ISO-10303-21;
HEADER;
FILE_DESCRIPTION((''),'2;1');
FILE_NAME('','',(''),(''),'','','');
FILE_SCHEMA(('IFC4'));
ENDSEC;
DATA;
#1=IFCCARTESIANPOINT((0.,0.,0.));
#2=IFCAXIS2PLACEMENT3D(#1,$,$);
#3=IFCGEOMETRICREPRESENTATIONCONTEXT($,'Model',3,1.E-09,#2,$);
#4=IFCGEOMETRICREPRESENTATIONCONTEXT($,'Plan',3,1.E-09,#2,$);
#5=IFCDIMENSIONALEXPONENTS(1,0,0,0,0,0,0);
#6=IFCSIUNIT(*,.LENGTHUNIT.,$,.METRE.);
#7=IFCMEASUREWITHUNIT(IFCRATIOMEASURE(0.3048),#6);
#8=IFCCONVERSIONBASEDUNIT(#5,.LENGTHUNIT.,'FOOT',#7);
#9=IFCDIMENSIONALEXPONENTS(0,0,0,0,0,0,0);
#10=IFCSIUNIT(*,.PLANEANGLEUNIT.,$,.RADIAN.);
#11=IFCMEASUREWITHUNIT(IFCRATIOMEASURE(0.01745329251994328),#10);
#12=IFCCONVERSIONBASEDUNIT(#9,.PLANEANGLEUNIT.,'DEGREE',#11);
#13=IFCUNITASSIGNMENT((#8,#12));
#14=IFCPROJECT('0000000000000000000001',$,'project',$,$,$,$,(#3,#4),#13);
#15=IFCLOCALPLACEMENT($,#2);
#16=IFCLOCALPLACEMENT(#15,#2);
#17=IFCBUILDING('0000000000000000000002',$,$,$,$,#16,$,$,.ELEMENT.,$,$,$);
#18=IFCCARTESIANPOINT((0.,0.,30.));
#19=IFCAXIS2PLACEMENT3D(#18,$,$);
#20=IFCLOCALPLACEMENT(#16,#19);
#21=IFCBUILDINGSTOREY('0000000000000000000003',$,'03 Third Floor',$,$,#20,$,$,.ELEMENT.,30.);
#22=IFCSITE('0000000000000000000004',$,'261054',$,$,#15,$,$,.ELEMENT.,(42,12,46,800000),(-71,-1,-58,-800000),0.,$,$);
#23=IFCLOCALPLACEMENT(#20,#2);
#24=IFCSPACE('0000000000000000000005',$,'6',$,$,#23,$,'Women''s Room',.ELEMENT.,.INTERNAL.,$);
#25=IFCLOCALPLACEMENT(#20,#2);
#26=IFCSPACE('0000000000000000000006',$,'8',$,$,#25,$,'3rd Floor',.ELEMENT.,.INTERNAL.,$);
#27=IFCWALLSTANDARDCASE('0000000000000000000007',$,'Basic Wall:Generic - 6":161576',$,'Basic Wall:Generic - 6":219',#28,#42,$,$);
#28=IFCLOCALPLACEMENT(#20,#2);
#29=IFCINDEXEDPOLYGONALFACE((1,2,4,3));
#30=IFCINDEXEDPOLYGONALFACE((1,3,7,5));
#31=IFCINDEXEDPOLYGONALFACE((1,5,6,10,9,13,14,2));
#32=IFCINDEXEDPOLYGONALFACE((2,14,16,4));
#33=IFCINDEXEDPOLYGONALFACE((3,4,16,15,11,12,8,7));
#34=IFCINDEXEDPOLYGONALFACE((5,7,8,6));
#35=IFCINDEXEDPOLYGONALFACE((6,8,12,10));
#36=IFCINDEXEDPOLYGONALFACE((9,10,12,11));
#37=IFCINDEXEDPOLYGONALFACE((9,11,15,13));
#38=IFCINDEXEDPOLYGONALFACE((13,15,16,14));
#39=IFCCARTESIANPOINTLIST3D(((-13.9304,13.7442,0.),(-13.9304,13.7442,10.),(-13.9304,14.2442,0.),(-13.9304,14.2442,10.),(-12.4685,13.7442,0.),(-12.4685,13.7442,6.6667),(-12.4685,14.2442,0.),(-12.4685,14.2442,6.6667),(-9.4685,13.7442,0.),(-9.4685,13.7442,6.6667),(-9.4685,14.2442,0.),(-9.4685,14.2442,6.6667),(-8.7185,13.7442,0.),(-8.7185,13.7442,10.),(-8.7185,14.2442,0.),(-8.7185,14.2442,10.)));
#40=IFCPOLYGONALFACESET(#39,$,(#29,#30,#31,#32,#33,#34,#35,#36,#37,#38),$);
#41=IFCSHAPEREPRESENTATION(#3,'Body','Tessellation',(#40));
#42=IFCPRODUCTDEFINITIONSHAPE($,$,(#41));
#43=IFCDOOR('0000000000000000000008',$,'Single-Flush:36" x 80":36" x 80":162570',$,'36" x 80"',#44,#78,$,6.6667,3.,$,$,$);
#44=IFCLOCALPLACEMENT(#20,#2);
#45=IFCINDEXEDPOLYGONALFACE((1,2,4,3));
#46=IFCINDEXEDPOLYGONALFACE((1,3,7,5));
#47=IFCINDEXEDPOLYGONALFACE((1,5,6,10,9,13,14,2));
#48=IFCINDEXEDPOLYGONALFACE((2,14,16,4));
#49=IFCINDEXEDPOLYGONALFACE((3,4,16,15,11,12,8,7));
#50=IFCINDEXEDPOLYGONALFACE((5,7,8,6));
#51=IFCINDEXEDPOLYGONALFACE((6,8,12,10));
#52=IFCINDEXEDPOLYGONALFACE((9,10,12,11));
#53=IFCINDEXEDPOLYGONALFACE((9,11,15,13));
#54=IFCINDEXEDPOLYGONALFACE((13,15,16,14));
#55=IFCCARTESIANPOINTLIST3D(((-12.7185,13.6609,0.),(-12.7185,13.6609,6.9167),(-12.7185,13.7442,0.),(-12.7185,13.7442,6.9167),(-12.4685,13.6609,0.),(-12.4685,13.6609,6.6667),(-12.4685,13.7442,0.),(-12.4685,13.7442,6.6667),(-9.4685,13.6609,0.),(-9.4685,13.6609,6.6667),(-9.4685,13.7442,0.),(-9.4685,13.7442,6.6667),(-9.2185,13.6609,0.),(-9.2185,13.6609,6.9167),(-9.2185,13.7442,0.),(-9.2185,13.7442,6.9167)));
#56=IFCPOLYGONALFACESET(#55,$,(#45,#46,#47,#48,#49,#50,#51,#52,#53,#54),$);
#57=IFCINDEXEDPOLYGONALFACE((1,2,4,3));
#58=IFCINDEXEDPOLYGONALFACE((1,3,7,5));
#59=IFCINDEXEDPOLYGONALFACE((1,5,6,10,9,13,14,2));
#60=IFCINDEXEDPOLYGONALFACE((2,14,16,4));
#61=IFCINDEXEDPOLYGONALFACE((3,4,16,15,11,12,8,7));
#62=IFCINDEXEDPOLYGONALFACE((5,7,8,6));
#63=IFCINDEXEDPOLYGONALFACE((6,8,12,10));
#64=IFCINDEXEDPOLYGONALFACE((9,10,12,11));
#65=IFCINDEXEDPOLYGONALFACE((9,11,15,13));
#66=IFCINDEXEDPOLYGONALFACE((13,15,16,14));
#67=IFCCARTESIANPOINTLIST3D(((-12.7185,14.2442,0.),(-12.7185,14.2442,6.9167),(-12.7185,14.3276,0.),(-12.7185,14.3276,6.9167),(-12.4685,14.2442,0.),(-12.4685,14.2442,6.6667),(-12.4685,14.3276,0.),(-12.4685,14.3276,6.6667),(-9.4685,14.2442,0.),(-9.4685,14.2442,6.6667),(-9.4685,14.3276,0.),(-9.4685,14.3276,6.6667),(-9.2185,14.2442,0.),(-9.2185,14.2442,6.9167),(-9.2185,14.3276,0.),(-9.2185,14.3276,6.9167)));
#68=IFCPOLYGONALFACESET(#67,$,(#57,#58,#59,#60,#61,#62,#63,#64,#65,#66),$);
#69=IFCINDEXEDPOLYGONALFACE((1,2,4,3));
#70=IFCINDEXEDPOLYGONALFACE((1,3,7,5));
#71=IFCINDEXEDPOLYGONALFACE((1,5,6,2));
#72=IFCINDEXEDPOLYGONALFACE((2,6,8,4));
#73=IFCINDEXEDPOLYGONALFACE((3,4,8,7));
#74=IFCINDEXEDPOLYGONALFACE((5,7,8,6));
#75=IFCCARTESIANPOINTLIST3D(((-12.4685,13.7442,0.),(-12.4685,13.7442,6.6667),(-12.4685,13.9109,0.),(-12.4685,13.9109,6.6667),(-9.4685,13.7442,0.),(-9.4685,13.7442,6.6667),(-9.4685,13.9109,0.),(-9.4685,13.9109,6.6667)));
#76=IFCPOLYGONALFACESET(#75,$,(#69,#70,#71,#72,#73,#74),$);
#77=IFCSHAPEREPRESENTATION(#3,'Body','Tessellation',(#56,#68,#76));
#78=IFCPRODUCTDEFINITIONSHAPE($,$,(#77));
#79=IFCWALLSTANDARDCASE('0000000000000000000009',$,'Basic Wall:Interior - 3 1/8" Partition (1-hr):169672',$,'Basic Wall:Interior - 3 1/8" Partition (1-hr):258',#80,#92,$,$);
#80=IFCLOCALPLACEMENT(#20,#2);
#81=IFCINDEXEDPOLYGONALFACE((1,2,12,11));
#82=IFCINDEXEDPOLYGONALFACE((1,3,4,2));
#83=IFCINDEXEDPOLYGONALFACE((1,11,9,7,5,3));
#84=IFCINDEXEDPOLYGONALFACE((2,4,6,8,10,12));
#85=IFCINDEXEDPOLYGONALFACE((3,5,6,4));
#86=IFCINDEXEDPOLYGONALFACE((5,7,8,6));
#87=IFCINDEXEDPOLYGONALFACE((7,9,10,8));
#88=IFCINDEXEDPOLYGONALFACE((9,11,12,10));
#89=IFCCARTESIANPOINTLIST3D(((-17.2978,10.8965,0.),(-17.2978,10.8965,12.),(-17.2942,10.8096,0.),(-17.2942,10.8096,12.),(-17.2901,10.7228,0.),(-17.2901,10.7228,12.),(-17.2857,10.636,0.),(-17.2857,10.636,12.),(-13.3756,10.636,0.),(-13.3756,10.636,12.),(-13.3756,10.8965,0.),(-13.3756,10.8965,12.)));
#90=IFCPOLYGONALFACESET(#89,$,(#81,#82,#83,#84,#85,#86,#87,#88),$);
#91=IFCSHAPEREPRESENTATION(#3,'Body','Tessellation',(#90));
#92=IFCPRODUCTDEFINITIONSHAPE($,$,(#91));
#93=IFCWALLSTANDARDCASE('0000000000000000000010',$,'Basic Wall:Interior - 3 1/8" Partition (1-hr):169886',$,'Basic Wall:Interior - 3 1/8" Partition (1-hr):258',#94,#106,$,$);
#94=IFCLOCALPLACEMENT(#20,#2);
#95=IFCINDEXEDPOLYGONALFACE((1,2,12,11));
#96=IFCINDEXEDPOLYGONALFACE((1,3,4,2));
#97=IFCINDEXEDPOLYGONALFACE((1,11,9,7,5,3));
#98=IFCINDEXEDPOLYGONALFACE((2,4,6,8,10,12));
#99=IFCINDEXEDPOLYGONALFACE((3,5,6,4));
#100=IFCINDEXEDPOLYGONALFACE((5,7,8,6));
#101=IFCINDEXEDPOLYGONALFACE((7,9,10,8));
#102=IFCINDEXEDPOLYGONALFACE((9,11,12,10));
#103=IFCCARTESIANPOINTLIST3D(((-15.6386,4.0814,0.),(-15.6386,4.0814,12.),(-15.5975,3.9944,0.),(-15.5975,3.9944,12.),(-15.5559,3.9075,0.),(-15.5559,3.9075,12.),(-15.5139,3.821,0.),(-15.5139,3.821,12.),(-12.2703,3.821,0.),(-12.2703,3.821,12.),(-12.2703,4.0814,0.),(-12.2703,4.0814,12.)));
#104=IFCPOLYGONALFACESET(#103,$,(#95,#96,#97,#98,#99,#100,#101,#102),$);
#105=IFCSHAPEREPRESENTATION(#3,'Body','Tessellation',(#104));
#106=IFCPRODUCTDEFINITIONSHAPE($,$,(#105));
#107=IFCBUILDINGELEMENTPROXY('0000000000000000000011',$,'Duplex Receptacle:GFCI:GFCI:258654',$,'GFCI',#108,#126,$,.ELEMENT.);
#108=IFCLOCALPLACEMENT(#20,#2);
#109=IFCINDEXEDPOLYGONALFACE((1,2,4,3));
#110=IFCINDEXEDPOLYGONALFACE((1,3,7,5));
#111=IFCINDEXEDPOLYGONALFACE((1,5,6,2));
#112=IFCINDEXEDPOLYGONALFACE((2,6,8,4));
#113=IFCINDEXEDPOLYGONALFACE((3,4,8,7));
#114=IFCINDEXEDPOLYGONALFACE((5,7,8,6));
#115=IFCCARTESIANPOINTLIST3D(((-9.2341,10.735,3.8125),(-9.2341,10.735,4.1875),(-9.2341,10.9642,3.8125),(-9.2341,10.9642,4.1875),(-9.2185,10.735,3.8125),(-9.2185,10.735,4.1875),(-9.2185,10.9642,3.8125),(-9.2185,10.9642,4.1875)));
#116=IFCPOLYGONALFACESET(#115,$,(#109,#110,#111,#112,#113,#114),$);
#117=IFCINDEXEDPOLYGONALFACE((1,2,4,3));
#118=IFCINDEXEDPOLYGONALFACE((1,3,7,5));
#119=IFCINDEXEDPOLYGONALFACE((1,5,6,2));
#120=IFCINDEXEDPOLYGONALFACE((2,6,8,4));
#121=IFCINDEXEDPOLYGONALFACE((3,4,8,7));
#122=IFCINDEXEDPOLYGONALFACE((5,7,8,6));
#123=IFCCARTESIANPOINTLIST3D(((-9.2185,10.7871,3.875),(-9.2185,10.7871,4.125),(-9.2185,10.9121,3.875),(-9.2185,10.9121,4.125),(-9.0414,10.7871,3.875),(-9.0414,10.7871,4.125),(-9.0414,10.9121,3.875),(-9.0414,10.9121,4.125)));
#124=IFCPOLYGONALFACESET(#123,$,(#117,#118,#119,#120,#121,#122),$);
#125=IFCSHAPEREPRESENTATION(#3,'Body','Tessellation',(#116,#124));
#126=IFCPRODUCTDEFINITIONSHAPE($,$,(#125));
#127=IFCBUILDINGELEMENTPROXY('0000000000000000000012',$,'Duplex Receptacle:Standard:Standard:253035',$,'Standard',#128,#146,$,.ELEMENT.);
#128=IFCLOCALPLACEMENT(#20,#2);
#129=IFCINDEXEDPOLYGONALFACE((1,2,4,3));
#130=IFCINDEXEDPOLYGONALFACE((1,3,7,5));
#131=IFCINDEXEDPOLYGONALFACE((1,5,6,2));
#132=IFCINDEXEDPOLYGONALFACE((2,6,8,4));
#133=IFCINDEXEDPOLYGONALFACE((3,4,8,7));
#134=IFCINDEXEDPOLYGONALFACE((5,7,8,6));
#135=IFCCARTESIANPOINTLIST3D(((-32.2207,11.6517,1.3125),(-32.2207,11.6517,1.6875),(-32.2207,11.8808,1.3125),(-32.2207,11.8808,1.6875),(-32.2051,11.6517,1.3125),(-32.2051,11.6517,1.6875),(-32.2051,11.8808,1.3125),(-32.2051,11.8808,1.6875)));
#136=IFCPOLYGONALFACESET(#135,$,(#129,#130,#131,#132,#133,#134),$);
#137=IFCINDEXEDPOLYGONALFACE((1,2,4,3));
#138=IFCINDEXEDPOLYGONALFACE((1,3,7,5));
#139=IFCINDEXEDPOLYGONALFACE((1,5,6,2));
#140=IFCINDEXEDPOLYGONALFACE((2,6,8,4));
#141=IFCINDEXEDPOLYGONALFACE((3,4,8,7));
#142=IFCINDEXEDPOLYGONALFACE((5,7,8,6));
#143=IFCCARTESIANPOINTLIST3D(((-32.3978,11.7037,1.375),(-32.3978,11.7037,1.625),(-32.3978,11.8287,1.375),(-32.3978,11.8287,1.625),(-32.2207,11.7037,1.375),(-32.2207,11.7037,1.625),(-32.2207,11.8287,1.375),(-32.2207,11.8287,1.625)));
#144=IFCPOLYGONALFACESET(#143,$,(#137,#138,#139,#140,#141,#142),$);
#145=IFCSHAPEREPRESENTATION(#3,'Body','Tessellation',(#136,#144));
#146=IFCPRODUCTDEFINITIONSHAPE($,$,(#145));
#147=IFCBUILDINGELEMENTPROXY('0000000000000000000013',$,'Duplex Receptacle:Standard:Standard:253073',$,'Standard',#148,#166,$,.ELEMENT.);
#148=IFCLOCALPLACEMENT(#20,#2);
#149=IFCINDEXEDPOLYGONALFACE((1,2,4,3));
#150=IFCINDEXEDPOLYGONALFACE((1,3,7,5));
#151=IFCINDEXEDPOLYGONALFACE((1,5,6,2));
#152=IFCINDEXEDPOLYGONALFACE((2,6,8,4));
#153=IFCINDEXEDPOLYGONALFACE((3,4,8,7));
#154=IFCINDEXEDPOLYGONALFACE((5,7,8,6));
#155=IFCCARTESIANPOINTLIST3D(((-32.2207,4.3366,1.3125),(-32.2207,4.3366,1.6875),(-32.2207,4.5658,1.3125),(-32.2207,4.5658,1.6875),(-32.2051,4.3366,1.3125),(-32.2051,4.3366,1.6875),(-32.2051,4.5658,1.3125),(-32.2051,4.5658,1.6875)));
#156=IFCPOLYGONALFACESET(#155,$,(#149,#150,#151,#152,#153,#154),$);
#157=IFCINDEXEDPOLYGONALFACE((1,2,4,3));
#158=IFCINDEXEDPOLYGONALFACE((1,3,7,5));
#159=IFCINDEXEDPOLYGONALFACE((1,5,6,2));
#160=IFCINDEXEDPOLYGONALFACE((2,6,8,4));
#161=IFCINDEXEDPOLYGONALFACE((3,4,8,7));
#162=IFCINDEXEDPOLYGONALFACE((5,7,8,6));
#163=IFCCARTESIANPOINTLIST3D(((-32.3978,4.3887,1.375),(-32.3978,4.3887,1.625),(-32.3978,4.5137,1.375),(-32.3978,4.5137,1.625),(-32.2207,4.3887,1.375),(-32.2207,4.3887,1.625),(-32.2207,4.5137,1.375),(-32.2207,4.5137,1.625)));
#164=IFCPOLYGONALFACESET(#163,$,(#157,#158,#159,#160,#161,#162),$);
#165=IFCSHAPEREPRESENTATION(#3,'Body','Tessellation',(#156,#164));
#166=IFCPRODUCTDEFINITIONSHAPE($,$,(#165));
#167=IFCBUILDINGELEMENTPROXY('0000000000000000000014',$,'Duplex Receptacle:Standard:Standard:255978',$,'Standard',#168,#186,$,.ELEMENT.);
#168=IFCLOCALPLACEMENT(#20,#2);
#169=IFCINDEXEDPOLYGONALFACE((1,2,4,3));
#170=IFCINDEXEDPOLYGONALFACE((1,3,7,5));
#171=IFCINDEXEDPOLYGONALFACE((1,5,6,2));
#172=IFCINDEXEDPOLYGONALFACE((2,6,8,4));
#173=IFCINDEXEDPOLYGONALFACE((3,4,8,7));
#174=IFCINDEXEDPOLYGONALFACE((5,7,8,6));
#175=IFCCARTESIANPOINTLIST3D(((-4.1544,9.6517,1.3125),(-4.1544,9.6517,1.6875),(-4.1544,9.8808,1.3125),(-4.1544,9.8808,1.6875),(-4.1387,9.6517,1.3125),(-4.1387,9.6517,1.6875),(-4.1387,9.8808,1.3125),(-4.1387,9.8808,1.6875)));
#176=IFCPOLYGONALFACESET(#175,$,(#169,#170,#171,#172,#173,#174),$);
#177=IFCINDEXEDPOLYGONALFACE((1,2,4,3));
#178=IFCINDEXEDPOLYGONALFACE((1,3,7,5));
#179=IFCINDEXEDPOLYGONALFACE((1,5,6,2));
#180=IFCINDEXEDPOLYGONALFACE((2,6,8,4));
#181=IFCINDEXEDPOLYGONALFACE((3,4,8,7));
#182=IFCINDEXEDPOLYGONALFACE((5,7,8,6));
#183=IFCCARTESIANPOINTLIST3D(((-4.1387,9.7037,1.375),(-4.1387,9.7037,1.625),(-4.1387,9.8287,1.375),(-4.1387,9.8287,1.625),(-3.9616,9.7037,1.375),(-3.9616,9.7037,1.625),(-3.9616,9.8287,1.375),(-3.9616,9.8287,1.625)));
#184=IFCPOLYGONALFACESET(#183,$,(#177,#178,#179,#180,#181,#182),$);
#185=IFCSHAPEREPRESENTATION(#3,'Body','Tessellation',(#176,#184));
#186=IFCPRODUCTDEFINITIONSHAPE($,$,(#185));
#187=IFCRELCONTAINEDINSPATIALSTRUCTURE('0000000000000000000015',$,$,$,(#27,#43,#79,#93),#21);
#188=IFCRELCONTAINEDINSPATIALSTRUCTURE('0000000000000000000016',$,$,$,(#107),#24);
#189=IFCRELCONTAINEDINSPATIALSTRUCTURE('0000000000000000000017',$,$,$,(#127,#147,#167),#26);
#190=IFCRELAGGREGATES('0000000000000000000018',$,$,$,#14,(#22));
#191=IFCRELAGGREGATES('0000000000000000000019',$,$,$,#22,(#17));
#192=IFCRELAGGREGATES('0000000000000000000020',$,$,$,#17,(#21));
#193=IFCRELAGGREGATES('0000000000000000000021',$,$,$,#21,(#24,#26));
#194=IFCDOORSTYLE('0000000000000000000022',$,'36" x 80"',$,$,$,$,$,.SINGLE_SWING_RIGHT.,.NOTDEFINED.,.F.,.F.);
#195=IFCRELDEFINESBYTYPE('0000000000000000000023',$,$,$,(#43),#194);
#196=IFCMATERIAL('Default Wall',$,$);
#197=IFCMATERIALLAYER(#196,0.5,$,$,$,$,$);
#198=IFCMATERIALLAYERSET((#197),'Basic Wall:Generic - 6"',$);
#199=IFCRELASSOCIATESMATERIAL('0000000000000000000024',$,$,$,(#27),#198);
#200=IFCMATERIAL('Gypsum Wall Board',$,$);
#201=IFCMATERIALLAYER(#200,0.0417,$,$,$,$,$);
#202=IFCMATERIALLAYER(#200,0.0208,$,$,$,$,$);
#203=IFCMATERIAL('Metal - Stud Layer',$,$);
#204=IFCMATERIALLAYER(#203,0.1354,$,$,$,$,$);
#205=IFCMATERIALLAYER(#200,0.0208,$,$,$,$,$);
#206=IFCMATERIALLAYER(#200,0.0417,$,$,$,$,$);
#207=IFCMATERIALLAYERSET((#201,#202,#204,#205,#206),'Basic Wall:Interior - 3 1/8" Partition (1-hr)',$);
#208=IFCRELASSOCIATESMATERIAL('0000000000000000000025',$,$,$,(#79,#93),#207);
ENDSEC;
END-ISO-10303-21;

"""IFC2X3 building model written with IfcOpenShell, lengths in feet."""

from ifc_helpers import new_model, entity, si_unit, converted_unit, frame, frame_2d, origin, origin_2d_with_axis, place, context, project, spatial, polyline, circle_curve, parameter, trimmed, segment, composite_curve, rectangle, outline, extrude, source, transform, mapped, material, layer, layer_set, layer_usage, type_object, type_shapes, element, fill, save


model = new_model("IFC2X3")

# Units and contexts
model_context = context("Model", 3, precision=1e-09, world=origin())
plan_context = context("Plan", 3, precision=1e-09, world=origin())
ifc_project = project(units=[converted_unit("LENGTHUNIT", "FOOT", entity("IfcRatioMeasure", 0.3048), si_unit("LENGTHUNIT", "METRE"), dimensions=[1, 0, 0, 0, 0, 0, 0]), converted_unit("PLANEANGLEUNIT", "DEGREE", entity("IfcRatioMeasure", 0.01745329251994328), si_unit("PLANEANGLEUNIT", "RADIAN"), dimensions=[0, 0, 0, 0, 0, 0, 0])], contexts=[model_context, plan_context])

# Site, building, storey
site_placement = place(None, origin())
site = spatial("IfcSite", under=ifc_project, at=site_placement, Name="261054", CompositionType="ELEMENT", RefLatitude=(42, 12, 46, 800000), RefLongitude=(-71, -1, -58, -800000), RefElevation=0.0)
building_placement = place(site_placement, origin())
building = spatial("IfcBuilding", under=site, at=building_placement, CompositionType="ELEMENT")
storey_placement = place(building_placement, frame((0.0, 0.0, 30.0)))
storey = spatial("IfcBuildingStorey", under=building, at=storey_placement, Name="03 Third Floor", CompositionType="ELEMENT", Elevation=30.0)

# Wall, opening, door
ifc_material_1 = material(Name="Default Wall")
ifc_layer_1 = layer(ifc_material_1, 0.5)
ifc_layer_set_1 = layer_set([ifc_layer_1], Name="Basic Wall:Generic - 6\"")
ifc_layer_usage_1 = layer_usage(ifc_layer_set_1, "AXIS2", "NEGATIVE", 0.25)
wall_1_placement = place(storey_placement, frame((-13.9304, 13.9942, 0.0)))
wall_1 = element("IfcWallStandardCase", 1, at=wall_1_placement, inside=storey, material=ifc_layer_usage_1, Name="Basic Wall:Generic - 6\":161576", ObjectType="Basic Wall:Generic - 6\":219", context=model_context, shape_type="SweptSolid", body=[
    extrude(rectangle(XDim=5.2119, YDim=0.5, at=frame_2d((2.606, 0.0), x_axis=(-1.0, 0.0))), origin(), (0.0, 0.0, 1.0), 10.0),
])
opening_1_placement = place(wall_1_placement, frame((4.4619, 0.25, 0.0)))
opening_1 = element("IfcOpeningElement", 2, at=opening_1_placement, cuts=wall_1, ObjectType="Opening", context=model_context, shape_type="SweptSolid", body=[
    extrude(rectangle(XDim=3.0, YDim=6.6667, at=frame_2d((3.3333, 1.5), x_axis=(0.0, 1.0))), frame((0.0, 0.0, 0.0), z_axis=(0.0, -1.0, 0.0), x_axis=(0.0, 0.0, 1.0)), (0.0, 0.0, 1.0), 0.5),
])
door_style = type_object("IfcDoorStyle", Name="36\" x 80\"", ConstructionType="NOTDEFINED", OperationType="SINGLE_SWING_RIGHT", ParameterTakesPrecedence=False, Sizeable=False)
shared_shape_1 = source(origin(), model_context, "Body", "SweptSolid", [
    extrude(outline(polyline([(-1.75, -3.5208), (1.75, -3.5208), (1.75, 3.3958), (1.5, 3.3958), (1.5, -3.2708), (-1.5, -3.2708), (-1.5, 3.3958), (-1.75, 3.3958), (-1.75, -3.5208)])), frame((1.5, 0.5, 3.3958), z_axis=(0.0, 1.0, 0.0), x_axis=(1.0, 0.0, 0.0)), (0.0, 0.0, 1.0), 0.0833),
    extrude(outline(polyline([(-3.5208, -1.75), (3.3958, -1.75), (3.3958, -1.5), (-3.2708, -1.5), (-3.2708, 1.5), (3.3958, 1.5), (3.3958, 1.75), (-3.5208, 1.75), (-3.5208, -1.75)])), frame((1.5, -0.0833, 3.3958), z_axis=(0.0, 1.0, 0.0), x_axis=(0.0, 0.0, -1.0)), (0.0, 0.0, 1.0), 0.0833),
    extrude(rectangle(XDim=0.1667, YDim=3.0, at=origin_2d_with_axis()), frame((1.5, 0.4167, 0.0), z_axis=(0.0, 0.0, 1.0), x_axis=(0.0, 1.0, 0.0)), (0.0, 0.0, 1.0), 6.6667),
])
type_shapes(door_style, [shared_shape_1])
door_1_placement = place(opening_1_placement, frame((0.0, 0.0, 0.0), z_axis=(0.0, 0.0, 1.0), x_axis=(-1.0, 0.0, 0.0)))
door_1 = element("IfcDoor", 3, at=door_1_placement, inside=storey, type_object=door_style, Name="Single-Flush:36\" x 80\":36\" x 80\":162570", ObjectType="36\" x 80\"", OverallHeight=6.6667, OverallWidth=3.0, context=model_context, shape_type="MappedRepresentation", body=[
    mapped(shared_shape_1, transform((0.0, 0.0, 0.0), scale=1.0)),
])
fill(opening_1, door_1)

# Walls
ifc_material_2 = material(Name="Gypsum Wall Board")
ifc_layer_2 = layer(ifc_material_2, 0.0417)
ifc_layer_3 = layer(ifc_material_2, 0.0208)
ifc_material_3 = material(Name="Metal - Stud Layer")
ifc_layer_4 = layer(ifc_material_3, 0.1354)
ifc_layer_5 = layer(ifc_material_2, 0.0208)
ifc_layer_6 = layer(ifc_material_2, 0.0417)
ifc_layer_set_2 = layer_set([ifc_layer_2, ifc_layer_3, ifc_layer_4, ifc_layer_5, ifc_layer_6], Name="Basic Wall:Interior - 3 1/8\" Partition (1-hr)")
ifc_layer_usage_2 = layer_usage(ifc_layer_set_2, "AXIS2", "NEGATIVE", 0.1302)
wall_2_placement = place(storey_placement, frame((-17.2978, 10.7662, 0.0)))
element("IfcWallStandardCase", 4, at=wall_2_placement, inside=storey, material=ifc_layer_usage_2, Name="Basic Wall:Interior - 3 1/8\" Partition (1-hr):169672", ObjectType="Basic Wall:Interior - 3 1/8\" Partition (1-hr):258", context=model_context, shape_type="SweptSolid", body=[
    extrude(outline(composite_curve([segment(polyline([(3.9222, -0.1302), (3.9222, 0.1302)]), True, "CONTINUOUS"), segment(polyline([(3.9222, 0.1302), (0.0, 0.1302)]), True, "CONTINUOUS"), segment(trimmed(circle_curve(frame_2d((17.6642, 0.8212), x_axis=(1.0, 0.0)), 17.6777), [parameter(182.240127)], [parameter(183.085093)], True, "PARAMETER"), True, "CONTINUOUS"), segment(polyline([(0.0121, -0.1302), (3.9222, -0.1302)]), True, "CONTINUOUS")], self_intersect=False)), origin(), (0.0, 0.0, 1.0), 12.0),
])
ifc_layer_usage_3 = layer_usage(ifc_layer_set_2, "AXIS2", "NEGATIVE", 0.1302)
wall_3_placement = place(storey_placement, frame((-15.6386, 3.9512, 0.0)))
element("IfcWallStandardCase", 5, at=wall_3_placement, inside=storey, material=ifc_layer_usage_3, Name="Basic Wall:Interior - 3 1/8\" Partition (1-hr):169886", ObjectType="Basic Wall:Interior - 3 1/8\" Partition (1-hr):258", context=model_context, shape_type="SweptSolid", body=[
    extrude(outline(composite_curve([segment(polyline([(3.3683, -0.1302), (3.3683, 0.1302)]), True, "CONTINUOUS"), segment(polyline([(3.3683, 0.1302), (0.0, 0.1302)]), True, "CONTINUOUS"), segment(trimmed(circle_curve(frame_2d((16.005, 7.6363), x_axis=(1.0, 0.0)), 17.6777), [parameter(205.125749)], [parameter(206.061634)], True, "PARAMETER"), True, "CONTINUOUS"), segment(polyline([(0.1247, -0.1302), (3.3683, -0.1302)]), True, "CONTINUOUS")], self_intersect=False)), origin(), (0.0, 0.0, 1.0), 12.0),
])

# Shared definitions
space_1_placement = place(storey_placement, origin())
space_1 = spatial("IfcSpace", under=storey, at=space_1_placement, Name="6", LongName="Women's Room", CompositionType="ELEMENT", InteriorOrExteriorSpace="INTERNAL")

# Building element proxy
shared_shape_2 = source(origin(), model_context, "Body", "SweptSolid", [
    extrude(rectangle(XDim=0.2292, YDim=0.375, at=origin_2d_with_axis()), frame((0.0, 0.0, 0.0), z_axis=(0.0, 0.0, 1.0), x_axis=(-1.0, 0.0, 0.0)), (0.0, 0.0, 1.0), 0.0156),
    extrude(rectangle(XDim=0.125, YDim=0.25, at=origin_2d_with_axis()), frame((0.0, 0.0, -0.1771), z_axis=(0.0, 0.0, 1.0), x_axis=(-1.0, 0.0, 0.0)), (0.0, 0.0, 1.0), 0.1771),
])
proxy_placement = place(space_1_placement, frame((-9.2185, 10.8496, 4.0), z_axis=(-1.0, 0.0, 0.0), x_axis=(0.0, -1.0, 0.0)))
element("IfcBuildingElementProxy", 6, at=proxy_placement, inside=space_1, Name="Duplex Receptacle:GFCI:GFCI:258654", ObjectType="GFCI", CompositionType="ELEMENT", context=model_context, shape_type="MappedRepresentation", body=[
    mapped(shared_shape_2, transform((0.0, 0.0, 0.0), scale=1.0)),
])

# Shared definitions
space_2_placement = place(storey_placement, origin())
space_2 = spatial("IfcSpace", under=storey, at=space_2_placement, Name="8", LongName="3rd Floor", CompositionType="ELEMENT", InteriorOrExteriorSpace="INTERNAL")

# Building element proxies
shared_shape_3 = source(origin(), model_context, "Body", "SweptSolid", [
    extrude(rectangle(XDim=0.2292, YDim=0.375, at=origin_2d_with_axis()), frame((0.0, 0.0, 0.0), z_axis=(0.0, 0.0, 1.0), x_axis=(-1.0, 0.0, 0.0)), (0.0, 0.0, 1.0), 0.0156),
    extrude(rectangle(XDim=0.125, YDim=0.25, at=origin_2d_with_axis()), frame((0.0, 0.0, -0.1771), z_axis=(0.0, 0.0, 1.0), x_axis=(-1.0, 0.0, 0.0)), (0.0, 0.0, 1.0), 0.1771),
])
for number, where, z_axis, x_axis, name in (
    (7, (-32.2207, 11.7662, 1.5), (1.0, 0.0, 0.0), (0.0, 1.0, 0.0), "Duplex Receptacle:Standard:Standard:253035"),
    (8, (-32.2207, 4.4512, 1.5), (1.0, 0.0, 0.0), (0.0, 1.0, 0.0), "Duplex Receptacle:Standard:Standard:253073"),
    (9, (-4.1387, 9.7662, 1.5), (-1.0, 0.0, 0.0), (0.0, -1.0, 0.0), "Duplex Receptacle:Standard:Standard:255978"),
):
    element("IfcBuildingElementProxy", number, at=place(space_2_placement, frame(where, z_axis=z_axis, x_axis=x_axis)), inside=space_2, Name=name, ObjectType="Standard", CompositionType="ELEMENT", context=model_context, shape_type="MappedRepresentation", body=[
        mapped(shared_shape_3, transform((0.0, 0.0, 0.0), scale=1.0)),
    ])

save(model, "model.ifc")
